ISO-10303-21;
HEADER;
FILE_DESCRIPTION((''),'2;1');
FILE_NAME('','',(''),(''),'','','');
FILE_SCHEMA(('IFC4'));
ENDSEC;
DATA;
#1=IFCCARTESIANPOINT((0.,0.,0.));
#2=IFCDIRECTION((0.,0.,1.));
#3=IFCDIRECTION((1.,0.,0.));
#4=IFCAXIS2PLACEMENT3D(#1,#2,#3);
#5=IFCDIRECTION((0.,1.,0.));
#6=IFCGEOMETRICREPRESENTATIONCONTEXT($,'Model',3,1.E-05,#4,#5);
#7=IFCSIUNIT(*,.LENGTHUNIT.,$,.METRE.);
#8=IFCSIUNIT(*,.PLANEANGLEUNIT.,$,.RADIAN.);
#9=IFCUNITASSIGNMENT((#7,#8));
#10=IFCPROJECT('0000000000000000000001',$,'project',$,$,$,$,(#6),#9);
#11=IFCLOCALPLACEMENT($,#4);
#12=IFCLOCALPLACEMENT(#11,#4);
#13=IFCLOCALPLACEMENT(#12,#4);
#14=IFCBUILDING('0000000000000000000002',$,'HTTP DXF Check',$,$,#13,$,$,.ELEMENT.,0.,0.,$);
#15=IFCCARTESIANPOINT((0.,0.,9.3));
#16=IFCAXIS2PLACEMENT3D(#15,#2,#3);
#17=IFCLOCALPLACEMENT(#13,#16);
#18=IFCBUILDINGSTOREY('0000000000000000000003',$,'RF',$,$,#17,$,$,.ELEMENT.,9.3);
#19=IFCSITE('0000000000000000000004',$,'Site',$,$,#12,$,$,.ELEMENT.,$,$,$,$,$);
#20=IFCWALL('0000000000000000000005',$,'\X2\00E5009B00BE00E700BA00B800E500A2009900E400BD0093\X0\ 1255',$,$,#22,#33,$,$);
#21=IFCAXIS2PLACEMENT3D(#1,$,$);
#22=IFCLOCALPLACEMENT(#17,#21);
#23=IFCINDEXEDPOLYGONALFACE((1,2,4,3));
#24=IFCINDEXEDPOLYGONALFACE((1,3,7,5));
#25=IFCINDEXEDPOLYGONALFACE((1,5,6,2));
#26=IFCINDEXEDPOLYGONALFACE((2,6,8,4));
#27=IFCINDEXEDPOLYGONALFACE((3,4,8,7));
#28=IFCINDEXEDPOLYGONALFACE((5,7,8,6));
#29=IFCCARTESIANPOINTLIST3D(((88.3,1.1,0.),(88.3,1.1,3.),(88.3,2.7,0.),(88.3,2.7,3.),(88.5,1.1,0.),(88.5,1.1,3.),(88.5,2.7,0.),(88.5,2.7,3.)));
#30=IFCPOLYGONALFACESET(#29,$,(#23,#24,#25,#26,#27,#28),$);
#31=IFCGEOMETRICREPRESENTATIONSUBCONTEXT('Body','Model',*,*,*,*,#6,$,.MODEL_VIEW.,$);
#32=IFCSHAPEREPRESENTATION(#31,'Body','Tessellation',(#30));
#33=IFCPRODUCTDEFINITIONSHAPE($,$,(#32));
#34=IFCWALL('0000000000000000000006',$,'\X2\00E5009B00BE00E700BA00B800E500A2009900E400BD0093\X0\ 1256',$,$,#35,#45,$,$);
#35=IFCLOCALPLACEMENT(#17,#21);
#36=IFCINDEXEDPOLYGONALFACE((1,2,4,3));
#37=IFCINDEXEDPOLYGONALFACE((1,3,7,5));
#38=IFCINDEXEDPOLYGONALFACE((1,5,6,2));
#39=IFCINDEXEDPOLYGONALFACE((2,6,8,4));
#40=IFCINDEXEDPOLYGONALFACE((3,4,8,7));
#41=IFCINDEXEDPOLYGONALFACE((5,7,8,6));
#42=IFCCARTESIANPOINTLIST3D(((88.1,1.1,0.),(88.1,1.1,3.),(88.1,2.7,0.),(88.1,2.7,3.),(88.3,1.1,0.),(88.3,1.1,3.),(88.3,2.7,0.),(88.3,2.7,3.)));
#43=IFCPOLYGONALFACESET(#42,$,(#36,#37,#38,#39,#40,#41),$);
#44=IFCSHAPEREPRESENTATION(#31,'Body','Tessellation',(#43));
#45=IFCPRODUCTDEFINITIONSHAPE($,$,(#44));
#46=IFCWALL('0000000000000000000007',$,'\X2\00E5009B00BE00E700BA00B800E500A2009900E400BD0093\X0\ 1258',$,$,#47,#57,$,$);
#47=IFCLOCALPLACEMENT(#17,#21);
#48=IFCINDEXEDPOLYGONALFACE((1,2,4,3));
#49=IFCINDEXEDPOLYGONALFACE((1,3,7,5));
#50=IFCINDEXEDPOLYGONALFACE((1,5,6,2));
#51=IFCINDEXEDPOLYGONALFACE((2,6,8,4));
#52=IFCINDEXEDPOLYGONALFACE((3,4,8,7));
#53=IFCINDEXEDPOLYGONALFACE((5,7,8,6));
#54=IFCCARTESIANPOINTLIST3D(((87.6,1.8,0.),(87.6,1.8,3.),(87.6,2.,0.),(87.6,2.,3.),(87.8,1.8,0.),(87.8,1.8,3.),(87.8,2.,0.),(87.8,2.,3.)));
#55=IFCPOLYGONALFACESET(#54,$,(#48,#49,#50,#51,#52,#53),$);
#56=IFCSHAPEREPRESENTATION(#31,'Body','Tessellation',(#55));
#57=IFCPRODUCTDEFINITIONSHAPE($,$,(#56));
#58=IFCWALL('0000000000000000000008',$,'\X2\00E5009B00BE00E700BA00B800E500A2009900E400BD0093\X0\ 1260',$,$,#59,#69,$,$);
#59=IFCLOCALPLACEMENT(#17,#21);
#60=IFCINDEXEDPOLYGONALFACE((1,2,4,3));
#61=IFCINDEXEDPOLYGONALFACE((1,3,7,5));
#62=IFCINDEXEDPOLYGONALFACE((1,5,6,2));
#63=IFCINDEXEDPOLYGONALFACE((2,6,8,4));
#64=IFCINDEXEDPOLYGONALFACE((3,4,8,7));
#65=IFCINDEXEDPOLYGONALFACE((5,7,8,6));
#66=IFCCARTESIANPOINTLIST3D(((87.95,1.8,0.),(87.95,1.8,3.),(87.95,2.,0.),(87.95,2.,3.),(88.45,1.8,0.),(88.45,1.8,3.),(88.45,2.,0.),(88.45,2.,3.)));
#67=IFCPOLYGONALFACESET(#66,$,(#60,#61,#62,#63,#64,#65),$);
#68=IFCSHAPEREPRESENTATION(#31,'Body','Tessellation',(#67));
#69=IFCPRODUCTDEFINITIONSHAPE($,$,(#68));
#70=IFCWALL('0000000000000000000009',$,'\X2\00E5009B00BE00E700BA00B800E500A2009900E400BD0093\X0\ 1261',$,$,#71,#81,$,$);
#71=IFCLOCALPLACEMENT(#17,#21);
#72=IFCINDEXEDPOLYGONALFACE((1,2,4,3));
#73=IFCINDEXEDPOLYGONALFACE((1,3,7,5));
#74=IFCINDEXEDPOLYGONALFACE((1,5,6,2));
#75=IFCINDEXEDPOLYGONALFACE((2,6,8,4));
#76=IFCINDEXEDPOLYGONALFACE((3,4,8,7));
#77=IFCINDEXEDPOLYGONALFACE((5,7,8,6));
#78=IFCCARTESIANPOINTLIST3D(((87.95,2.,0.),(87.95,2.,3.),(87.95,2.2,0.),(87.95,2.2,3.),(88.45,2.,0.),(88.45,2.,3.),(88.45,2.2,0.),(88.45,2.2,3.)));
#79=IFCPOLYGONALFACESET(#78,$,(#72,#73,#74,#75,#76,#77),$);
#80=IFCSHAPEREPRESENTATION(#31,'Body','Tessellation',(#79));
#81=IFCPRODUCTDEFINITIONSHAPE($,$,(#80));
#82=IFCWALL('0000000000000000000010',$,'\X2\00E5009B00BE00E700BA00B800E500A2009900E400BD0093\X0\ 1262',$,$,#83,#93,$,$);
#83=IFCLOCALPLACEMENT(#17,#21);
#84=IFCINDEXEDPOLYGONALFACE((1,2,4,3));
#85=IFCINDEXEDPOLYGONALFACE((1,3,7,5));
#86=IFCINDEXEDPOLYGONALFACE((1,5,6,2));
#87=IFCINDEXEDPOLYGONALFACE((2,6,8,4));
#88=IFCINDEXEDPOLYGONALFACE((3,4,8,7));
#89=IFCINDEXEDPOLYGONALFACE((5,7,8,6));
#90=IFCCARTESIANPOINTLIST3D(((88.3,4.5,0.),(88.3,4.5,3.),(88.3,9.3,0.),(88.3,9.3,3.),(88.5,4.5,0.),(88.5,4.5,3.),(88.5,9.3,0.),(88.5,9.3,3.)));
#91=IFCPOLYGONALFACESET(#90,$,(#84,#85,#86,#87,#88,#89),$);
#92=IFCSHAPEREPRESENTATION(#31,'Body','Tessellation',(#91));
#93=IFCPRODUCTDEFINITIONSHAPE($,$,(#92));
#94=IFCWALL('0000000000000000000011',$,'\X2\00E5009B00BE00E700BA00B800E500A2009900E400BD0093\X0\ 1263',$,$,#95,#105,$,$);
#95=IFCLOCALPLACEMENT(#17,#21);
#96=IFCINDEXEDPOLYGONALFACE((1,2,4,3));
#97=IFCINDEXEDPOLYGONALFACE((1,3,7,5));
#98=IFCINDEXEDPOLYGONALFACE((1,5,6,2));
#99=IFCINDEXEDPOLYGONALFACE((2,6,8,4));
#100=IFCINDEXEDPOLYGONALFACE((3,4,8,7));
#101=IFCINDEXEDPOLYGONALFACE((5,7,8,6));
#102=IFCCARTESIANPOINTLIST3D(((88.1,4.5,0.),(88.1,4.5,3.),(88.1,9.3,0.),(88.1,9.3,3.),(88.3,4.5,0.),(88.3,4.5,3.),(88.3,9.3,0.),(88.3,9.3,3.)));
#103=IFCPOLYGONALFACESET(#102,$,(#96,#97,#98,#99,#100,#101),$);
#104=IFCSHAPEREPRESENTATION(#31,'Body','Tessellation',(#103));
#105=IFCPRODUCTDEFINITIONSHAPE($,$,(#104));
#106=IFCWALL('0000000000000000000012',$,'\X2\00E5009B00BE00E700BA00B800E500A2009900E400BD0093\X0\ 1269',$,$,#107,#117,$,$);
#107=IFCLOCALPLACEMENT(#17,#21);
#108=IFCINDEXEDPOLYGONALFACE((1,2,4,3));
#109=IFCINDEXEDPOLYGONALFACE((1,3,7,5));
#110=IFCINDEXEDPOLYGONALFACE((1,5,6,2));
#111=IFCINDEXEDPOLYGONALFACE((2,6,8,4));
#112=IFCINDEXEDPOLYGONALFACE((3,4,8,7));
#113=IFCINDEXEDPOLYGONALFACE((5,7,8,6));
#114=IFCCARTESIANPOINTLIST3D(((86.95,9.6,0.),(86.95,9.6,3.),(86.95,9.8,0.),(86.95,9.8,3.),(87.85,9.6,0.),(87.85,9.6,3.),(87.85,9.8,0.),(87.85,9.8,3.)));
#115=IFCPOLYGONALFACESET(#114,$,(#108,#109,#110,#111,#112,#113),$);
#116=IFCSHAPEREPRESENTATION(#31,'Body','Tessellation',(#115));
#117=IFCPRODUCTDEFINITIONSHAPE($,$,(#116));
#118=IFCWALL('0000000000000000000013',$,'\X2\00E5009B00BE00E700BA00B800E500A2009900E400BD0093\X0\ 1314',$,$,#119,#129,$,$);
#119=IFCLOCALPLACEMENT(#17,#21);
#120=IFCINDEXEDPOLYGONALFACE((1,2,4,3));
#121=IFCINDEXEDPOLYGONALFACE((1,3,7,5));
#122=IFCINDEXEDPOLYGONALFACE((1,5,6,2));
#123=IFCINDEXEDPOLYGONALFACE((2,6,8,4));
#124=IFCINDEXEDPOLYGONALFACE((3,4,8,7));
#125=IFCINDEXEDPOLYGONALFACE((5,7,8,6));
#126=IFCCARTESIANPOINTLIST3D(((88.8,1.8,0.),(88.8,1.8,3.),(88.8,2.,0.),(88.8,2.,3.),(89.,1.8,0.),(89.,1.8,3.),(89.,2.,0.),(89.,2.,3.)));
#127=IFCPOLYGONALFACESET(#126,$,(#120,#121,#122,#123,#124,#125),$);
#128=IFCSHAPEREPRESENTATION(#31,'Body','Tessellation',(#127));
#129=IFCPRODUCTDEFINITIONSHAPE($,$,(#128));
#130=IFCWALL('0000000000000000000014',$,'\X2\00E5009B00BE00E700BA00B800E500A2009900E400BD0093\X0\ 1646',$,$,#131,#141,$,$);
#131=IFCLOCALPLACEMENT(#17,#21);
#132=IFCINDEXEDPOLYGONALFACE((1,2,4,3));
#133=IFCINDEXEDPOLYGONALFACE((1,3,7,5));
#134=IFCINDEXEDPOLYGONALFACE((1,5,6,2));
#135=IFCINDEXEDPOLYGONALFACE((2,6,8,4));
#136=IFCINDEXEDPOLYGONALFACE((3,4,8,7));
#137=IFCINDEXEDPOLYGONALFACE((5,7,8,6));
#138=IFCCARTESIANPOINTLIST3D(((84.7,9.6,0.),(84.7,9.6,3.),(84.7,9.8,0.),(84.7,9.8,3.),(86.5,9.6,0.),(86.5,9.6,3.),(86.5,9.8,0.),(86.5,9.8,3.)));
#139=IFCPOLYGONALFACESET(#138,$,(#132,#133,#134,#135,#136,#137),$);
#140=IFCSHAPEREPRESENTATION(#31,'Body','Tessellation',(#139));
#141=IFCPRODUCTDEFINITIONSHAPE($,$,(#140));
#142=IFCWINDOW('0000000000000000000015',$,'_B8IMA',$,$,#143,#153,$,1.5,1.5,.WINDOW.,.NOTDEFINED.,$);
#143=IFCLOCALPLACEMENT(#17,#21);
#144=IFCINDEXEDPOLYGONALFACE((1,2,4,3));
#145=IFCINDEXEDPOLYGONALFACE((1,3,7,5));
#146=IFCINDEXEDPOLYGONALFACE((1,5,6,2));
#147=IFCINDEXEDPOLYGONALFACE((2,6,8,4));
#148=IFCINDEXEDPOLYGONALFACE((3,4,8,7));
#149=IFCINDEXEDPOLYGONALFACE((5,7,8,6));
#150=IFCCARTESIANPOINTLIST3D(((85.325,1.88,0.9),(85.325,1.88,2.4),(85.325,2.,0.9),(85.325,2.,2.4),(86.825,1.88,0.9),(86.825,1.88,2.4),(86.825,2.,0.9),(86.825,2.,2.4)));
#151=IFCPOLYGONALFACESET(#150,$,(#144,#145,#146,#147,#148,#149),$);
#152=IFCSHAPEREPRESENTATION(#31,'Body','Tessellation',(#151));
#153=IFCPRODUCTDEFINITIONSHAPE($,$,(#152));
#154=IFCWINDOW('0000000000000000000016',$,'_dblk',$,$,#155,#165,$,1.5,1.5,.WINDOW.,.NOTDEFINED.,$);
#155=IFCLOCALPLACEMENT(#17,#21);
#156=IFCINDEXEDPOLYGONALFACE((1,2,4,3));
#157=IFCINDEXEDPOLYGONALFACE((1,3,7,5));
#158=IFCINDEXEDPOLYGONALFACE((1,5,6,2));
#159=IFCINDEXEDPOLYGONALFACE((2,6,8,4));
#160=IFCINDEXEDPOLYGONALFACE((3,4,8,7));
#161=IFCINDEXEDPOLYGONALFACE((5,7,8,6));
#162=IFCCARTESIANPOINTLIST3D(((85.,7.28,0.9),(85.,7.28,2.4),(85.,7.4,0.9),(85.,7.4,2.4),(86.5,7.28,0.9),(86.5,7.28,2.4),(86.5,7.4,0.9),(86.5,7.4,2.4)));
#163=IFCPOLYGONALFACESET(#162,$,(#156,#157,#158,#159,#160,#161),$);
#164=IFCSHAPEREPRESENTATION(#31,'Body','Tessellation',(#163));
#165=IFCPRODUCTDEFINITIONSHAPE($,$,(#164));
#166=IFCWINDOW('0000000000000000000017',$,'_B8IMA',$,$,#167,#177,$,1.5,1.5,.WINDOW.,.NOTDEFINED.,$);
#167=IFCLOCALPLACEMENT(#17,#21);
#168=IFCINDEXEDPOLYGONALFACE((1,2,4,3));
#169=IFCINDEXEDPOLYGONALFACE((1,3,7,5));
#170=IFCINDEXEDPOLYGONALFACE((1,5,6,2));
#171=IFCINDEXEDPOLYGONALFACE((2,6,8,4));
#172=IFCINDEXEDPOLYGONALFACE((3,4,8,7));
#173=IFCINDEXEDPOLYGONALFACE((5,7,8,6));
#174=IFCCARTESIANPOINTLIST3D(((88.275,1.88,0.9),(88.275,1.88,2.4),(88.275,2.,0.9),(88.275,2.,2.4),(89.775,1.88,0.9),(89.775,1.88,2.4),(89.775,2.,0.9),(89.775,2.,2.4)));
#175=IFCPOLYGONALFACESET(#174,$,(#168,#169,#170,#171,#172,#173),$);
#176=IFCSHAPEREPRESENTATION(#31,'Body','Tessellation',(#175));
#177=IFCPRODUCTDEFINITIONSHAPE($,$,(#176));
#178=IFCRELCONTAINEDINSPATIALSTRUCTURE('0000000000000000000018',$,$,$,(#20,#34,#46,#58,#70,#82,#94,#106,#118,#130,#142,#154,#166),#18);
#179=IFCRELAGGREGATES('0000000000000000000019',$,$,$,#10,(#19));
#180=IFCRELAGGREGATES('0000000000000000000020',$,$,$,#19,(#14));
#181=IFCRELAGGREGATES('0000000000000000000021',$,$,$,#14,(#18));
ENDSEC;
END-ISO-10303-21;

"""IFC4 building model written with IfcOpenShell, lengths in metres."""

from ifc_helpers import new_model, si_unit, direction, frame, frame_2d, origin_with_axes, place, context, subcontext, project, spatial, rectangle, extrude, element, save


model = new_model("IFC4")

# Units and contexts
model_context = context("Model", 3, precision=1e-05, world=origin_with_axes(), true_north=direction((0.0, 1.0, 0.0)))
body_context = subcontext(model_context, "Body", "Model", "MODEL_VIEW")
ifc_project = project(units=[si_unit("LENGTHUNIT", "METRE"), si_unit("PLANEANGLEUNIT", "RADIAN")], contexts=[model_context])

# Site, building, storey
placement = place(None, origin_with_axes())
site_placement = place(placement, origin_with_axes())
site = spatial("IfcSite", under=ifc_project, at=site_placement, Name="Site", CompositionType="ELEMENT")
building_placement = place(site_placement, origin_with_axes())
building = spatial("IfcBuilding", under=site, at=building_placement, Name="HTTP DXF Check", CompositionType="ELEMENT", ElevationOfRefHeight=0.0, ElevationOfTerrain=0.0)
storey_placement = place(building_placement, frame((0.0, 0.0, 9.3), z_axis=(0.0, 0.0, 1.0), x_axis=(1.0, 0.0, 0.0)))
storey = spatial("IfcBuildingStorey", under=building, at=storey_placement, Name="RF", CompositionType="ELEMENT", Elevation=9.3)

# Walls
for number, where, z_axis, x_axis, name in (
    (1, (88.4, 1.9, 0.0), (0.0, 0.0, 1.0), (0.0, -1.0, 0.0), "å\u009b¾çº¸å¢\u0099ä½\u0093 1255"),
    (2, (88.2, 1.9, 0.0), (0.0, 0.0, 1.0), (0.0, -1.0, 0.0), "å\u009b¾çº¸å¢\u0099ä½\u0093 1256"),
):
    element("IfcWall", number, at=place(storey_placement, frame(where, z_axis=z_axis, x_axis=x_axis)), inside=storey, Name=name, context=body_context, shape_type="SweptSolid", body=[
        extrude(rectangle(XDim=1.6, YDim=0.2, at=frame_2d((0.0, 0.0), x_axis=(1.0, 0.0, 0.0))), frame((0.0, 0.0, 0.0), z_axis=(0.0, 0.0, 1.0)), (0.0, 0.0, 1.0), 3.0),
    ])
wall_1_placement = place(storey_placement, frame((87.7, 1.9, 0.0), z_axis=(0.0, 0.0, 1.0), x_axis=(0.0, 1.0, 0.0)))
element("IfcWall", 3, at=wall_1_placement, inside=storey, Name="å\u009b¾çº¸å¢\u0099ä½\u0093 1258", context=body_context, shape_type="SweptSolid", body=[
    extrude(rectangle(XDim=0.2, YDim=0.2, at=frame_2d((0.0, 0.0), x_axis=(1.0, 0.0, 0.0))), frame((0.0, 0.0, 0.0), z_axis=(0.0, 0.0, 1.0)), (0.0, 0.0, 1.0), 3.0),
])
for number, where, z_axis, x_axis, name in (
    (4, (88.2, 1.9, 0.0), (0.0, 0.0, 1.0), (-1.0, 0.0, 0.0), "å\u009b¾çº¸å¢\u0099ä½\u0093 1260"),
    (5, (88.2, 2.1, 0.0), (0.0, 0.0, 1.0), (-1.0, 0.0, 0.0), "å\u009b¾çº¸å¢\u0099ä½\u0093 1261"),
):
    element("IfcWall", number, at=place(storey_placement, frame(where, z_axis=z_axis, x_axis=x_axis)), inside=storey, Name=name, context=body_context, shape_type="SweptSolid", body=[
        extrude(rectangle(XDim=0.5, YDim=0.2, at=frame_2d((0.0, 0.0), x_axis=(1.0, 0.0, 0.0))), frame((0.0, 0.0, 0.0), z_axis=(0.0, 0.0, 1.0)), (0.0, 0.0, 1.0), 3.0),
    ])
for number, where, z_axis, x_axis, name in (
    (6, (88.4, 6.9, 0.0), (0.0, 0.0, 1.0), (0.0, -1.0, 0.0), "å\u009b¾çº¸å¢\u0099ä½\u0093 1262"),
    (7, (88.2, 6.9, 0.0), (0.0, 0.0, 1.0), (0.0, -1.0, 0.0), "å\u009b¾çº¸å¢\u0099ä½\u0093 1263"),
):
    element("IfcWall", number, at=place(storey_placement, frame(where, z_axis=z_axis, x_axis=x_axis)), inside=storey, Name=name, context=body_context, shape_type="SweptSolid", body=[
        extrude(rectangle(XDim=4.8, YDim=0.2, at=frame_2d((0.0, 0.0), x_axis=(1.0, 0.0, 0.0))), frame((0.0, 0.0, 0.0), z_axis=(0.0, 0.0, 1.0)), (0.0, 0.0, 1.0), 3.0),
    ])
wall_2_placement = place(storey_placement, frame((87.4, 9.7, 0.0), z_axis=(0.0, 0.0, 1.0), x_axis=(1.0, 0.0, 0.0)))
element("IfcWall", 8, at=wall_2_placement, inside=storey, Name="å\u009b¾çº¸å¢\u0099ä½\u0093 1269", context=body_context, shape_type="SweptSolid", body=[
    extrude(rectangle(XDim=0.9, YDim=0.2, at=frame_2d((0.0, 0.0), x_axis=(1.0, 0.0, 0.0))), frame((0.0, 0.0, 0.0), z_axis=(0.0, 0.0, 1.0)), (0.0, 0.0, 1.0), 3.0),
])
wall_3_placement = place(storey_placement, frame((88.9, 1.9, 0.0), z_axis=(0.0, 0.0, 1.0), x_axis=(0.0, 1.0, 0.0)))
element("IfcWall", 9, at=wall_3_placement, inside=storey, Name="å\u009b¾çº¸å¢\u0099ä½\u0093 1314", context=body_context, shape_type="SweptSolid", body=[
    extrude(rectangle(XDim=0.2, YDim=0.2, at=frame_2d((0.0, 0.0), x_axis=(1.0, 0.0, 0.0))), frame((0.0, 0.0, 0.0), z_axis=(0.0, 0.0, 1.0)), (0.0, 0.0, 1.0), 3.0),
])
wall_4_placement = place(storey_placement, frame((85.6, 9.7, 0.0), z_axis=(0.0, 0.0, 1.0), x_axis=(1.0, 0.0, 0.0)))
element("IfcWall", 10, at=wall_4_placement, inside=storey, Name="å\u009b¾çº¸å¢\u0099ä½\u0093 1646", context=body_context, shape_type="SweptSolid", body=[
    extrude(rectangle(XDim=1.8, YDim=0.2, at=frame_2d((0.0, 0.0), x_axis=(1.0, 0.0, 0.0))), frame((0.0, 0.0, 0.0), z_axis=(0.0, 0.0, 1.0)), (0.0, 0.0, 1.0), 3.0),
])

# Windows
for number, where, z_axis, x_axis, name in (
    (11, (86.075, 1.94, 0.9), (0.0, 0.0, 1.0), (1.0, 0.0, 0.0), "_B8IMA"),
    (12, (85.75, 7.34, 0.9), (0.0, 0.0, 1.0), (1.0, 0.0, 0.0), "_dblk"),
    (13, (89.025, 1.94, 0.9), (0.0, 0.0, 1.0), (1.0, 0.0, 0.0), "_B8IMA"),
):
    element("IfcWindow", number, at=place(storey_placement, frame(where, z_axis=z_axis, x_axis=x_axis)), inside=storey, Name=name, OverallHeight=1.5, OverallWidth=1.5, PartitioningType="NOTDEFINED", PredefinedType="WINDOW", context=body_context, shape_type="SweptSolid", body=[
        extrude(rectangle(XDim=1.5, YDim=0.12, at=frame_2d((0.0, 0.0), x_axis=(1.0, 0.0, 0.0))), frame((0.0, 0.0, 0.0), z_axis=(0.0, 0.0, 1.0)), (0.0, 0.0, 1.0), 1.5),
    ])

save(model, "model.ifc")
